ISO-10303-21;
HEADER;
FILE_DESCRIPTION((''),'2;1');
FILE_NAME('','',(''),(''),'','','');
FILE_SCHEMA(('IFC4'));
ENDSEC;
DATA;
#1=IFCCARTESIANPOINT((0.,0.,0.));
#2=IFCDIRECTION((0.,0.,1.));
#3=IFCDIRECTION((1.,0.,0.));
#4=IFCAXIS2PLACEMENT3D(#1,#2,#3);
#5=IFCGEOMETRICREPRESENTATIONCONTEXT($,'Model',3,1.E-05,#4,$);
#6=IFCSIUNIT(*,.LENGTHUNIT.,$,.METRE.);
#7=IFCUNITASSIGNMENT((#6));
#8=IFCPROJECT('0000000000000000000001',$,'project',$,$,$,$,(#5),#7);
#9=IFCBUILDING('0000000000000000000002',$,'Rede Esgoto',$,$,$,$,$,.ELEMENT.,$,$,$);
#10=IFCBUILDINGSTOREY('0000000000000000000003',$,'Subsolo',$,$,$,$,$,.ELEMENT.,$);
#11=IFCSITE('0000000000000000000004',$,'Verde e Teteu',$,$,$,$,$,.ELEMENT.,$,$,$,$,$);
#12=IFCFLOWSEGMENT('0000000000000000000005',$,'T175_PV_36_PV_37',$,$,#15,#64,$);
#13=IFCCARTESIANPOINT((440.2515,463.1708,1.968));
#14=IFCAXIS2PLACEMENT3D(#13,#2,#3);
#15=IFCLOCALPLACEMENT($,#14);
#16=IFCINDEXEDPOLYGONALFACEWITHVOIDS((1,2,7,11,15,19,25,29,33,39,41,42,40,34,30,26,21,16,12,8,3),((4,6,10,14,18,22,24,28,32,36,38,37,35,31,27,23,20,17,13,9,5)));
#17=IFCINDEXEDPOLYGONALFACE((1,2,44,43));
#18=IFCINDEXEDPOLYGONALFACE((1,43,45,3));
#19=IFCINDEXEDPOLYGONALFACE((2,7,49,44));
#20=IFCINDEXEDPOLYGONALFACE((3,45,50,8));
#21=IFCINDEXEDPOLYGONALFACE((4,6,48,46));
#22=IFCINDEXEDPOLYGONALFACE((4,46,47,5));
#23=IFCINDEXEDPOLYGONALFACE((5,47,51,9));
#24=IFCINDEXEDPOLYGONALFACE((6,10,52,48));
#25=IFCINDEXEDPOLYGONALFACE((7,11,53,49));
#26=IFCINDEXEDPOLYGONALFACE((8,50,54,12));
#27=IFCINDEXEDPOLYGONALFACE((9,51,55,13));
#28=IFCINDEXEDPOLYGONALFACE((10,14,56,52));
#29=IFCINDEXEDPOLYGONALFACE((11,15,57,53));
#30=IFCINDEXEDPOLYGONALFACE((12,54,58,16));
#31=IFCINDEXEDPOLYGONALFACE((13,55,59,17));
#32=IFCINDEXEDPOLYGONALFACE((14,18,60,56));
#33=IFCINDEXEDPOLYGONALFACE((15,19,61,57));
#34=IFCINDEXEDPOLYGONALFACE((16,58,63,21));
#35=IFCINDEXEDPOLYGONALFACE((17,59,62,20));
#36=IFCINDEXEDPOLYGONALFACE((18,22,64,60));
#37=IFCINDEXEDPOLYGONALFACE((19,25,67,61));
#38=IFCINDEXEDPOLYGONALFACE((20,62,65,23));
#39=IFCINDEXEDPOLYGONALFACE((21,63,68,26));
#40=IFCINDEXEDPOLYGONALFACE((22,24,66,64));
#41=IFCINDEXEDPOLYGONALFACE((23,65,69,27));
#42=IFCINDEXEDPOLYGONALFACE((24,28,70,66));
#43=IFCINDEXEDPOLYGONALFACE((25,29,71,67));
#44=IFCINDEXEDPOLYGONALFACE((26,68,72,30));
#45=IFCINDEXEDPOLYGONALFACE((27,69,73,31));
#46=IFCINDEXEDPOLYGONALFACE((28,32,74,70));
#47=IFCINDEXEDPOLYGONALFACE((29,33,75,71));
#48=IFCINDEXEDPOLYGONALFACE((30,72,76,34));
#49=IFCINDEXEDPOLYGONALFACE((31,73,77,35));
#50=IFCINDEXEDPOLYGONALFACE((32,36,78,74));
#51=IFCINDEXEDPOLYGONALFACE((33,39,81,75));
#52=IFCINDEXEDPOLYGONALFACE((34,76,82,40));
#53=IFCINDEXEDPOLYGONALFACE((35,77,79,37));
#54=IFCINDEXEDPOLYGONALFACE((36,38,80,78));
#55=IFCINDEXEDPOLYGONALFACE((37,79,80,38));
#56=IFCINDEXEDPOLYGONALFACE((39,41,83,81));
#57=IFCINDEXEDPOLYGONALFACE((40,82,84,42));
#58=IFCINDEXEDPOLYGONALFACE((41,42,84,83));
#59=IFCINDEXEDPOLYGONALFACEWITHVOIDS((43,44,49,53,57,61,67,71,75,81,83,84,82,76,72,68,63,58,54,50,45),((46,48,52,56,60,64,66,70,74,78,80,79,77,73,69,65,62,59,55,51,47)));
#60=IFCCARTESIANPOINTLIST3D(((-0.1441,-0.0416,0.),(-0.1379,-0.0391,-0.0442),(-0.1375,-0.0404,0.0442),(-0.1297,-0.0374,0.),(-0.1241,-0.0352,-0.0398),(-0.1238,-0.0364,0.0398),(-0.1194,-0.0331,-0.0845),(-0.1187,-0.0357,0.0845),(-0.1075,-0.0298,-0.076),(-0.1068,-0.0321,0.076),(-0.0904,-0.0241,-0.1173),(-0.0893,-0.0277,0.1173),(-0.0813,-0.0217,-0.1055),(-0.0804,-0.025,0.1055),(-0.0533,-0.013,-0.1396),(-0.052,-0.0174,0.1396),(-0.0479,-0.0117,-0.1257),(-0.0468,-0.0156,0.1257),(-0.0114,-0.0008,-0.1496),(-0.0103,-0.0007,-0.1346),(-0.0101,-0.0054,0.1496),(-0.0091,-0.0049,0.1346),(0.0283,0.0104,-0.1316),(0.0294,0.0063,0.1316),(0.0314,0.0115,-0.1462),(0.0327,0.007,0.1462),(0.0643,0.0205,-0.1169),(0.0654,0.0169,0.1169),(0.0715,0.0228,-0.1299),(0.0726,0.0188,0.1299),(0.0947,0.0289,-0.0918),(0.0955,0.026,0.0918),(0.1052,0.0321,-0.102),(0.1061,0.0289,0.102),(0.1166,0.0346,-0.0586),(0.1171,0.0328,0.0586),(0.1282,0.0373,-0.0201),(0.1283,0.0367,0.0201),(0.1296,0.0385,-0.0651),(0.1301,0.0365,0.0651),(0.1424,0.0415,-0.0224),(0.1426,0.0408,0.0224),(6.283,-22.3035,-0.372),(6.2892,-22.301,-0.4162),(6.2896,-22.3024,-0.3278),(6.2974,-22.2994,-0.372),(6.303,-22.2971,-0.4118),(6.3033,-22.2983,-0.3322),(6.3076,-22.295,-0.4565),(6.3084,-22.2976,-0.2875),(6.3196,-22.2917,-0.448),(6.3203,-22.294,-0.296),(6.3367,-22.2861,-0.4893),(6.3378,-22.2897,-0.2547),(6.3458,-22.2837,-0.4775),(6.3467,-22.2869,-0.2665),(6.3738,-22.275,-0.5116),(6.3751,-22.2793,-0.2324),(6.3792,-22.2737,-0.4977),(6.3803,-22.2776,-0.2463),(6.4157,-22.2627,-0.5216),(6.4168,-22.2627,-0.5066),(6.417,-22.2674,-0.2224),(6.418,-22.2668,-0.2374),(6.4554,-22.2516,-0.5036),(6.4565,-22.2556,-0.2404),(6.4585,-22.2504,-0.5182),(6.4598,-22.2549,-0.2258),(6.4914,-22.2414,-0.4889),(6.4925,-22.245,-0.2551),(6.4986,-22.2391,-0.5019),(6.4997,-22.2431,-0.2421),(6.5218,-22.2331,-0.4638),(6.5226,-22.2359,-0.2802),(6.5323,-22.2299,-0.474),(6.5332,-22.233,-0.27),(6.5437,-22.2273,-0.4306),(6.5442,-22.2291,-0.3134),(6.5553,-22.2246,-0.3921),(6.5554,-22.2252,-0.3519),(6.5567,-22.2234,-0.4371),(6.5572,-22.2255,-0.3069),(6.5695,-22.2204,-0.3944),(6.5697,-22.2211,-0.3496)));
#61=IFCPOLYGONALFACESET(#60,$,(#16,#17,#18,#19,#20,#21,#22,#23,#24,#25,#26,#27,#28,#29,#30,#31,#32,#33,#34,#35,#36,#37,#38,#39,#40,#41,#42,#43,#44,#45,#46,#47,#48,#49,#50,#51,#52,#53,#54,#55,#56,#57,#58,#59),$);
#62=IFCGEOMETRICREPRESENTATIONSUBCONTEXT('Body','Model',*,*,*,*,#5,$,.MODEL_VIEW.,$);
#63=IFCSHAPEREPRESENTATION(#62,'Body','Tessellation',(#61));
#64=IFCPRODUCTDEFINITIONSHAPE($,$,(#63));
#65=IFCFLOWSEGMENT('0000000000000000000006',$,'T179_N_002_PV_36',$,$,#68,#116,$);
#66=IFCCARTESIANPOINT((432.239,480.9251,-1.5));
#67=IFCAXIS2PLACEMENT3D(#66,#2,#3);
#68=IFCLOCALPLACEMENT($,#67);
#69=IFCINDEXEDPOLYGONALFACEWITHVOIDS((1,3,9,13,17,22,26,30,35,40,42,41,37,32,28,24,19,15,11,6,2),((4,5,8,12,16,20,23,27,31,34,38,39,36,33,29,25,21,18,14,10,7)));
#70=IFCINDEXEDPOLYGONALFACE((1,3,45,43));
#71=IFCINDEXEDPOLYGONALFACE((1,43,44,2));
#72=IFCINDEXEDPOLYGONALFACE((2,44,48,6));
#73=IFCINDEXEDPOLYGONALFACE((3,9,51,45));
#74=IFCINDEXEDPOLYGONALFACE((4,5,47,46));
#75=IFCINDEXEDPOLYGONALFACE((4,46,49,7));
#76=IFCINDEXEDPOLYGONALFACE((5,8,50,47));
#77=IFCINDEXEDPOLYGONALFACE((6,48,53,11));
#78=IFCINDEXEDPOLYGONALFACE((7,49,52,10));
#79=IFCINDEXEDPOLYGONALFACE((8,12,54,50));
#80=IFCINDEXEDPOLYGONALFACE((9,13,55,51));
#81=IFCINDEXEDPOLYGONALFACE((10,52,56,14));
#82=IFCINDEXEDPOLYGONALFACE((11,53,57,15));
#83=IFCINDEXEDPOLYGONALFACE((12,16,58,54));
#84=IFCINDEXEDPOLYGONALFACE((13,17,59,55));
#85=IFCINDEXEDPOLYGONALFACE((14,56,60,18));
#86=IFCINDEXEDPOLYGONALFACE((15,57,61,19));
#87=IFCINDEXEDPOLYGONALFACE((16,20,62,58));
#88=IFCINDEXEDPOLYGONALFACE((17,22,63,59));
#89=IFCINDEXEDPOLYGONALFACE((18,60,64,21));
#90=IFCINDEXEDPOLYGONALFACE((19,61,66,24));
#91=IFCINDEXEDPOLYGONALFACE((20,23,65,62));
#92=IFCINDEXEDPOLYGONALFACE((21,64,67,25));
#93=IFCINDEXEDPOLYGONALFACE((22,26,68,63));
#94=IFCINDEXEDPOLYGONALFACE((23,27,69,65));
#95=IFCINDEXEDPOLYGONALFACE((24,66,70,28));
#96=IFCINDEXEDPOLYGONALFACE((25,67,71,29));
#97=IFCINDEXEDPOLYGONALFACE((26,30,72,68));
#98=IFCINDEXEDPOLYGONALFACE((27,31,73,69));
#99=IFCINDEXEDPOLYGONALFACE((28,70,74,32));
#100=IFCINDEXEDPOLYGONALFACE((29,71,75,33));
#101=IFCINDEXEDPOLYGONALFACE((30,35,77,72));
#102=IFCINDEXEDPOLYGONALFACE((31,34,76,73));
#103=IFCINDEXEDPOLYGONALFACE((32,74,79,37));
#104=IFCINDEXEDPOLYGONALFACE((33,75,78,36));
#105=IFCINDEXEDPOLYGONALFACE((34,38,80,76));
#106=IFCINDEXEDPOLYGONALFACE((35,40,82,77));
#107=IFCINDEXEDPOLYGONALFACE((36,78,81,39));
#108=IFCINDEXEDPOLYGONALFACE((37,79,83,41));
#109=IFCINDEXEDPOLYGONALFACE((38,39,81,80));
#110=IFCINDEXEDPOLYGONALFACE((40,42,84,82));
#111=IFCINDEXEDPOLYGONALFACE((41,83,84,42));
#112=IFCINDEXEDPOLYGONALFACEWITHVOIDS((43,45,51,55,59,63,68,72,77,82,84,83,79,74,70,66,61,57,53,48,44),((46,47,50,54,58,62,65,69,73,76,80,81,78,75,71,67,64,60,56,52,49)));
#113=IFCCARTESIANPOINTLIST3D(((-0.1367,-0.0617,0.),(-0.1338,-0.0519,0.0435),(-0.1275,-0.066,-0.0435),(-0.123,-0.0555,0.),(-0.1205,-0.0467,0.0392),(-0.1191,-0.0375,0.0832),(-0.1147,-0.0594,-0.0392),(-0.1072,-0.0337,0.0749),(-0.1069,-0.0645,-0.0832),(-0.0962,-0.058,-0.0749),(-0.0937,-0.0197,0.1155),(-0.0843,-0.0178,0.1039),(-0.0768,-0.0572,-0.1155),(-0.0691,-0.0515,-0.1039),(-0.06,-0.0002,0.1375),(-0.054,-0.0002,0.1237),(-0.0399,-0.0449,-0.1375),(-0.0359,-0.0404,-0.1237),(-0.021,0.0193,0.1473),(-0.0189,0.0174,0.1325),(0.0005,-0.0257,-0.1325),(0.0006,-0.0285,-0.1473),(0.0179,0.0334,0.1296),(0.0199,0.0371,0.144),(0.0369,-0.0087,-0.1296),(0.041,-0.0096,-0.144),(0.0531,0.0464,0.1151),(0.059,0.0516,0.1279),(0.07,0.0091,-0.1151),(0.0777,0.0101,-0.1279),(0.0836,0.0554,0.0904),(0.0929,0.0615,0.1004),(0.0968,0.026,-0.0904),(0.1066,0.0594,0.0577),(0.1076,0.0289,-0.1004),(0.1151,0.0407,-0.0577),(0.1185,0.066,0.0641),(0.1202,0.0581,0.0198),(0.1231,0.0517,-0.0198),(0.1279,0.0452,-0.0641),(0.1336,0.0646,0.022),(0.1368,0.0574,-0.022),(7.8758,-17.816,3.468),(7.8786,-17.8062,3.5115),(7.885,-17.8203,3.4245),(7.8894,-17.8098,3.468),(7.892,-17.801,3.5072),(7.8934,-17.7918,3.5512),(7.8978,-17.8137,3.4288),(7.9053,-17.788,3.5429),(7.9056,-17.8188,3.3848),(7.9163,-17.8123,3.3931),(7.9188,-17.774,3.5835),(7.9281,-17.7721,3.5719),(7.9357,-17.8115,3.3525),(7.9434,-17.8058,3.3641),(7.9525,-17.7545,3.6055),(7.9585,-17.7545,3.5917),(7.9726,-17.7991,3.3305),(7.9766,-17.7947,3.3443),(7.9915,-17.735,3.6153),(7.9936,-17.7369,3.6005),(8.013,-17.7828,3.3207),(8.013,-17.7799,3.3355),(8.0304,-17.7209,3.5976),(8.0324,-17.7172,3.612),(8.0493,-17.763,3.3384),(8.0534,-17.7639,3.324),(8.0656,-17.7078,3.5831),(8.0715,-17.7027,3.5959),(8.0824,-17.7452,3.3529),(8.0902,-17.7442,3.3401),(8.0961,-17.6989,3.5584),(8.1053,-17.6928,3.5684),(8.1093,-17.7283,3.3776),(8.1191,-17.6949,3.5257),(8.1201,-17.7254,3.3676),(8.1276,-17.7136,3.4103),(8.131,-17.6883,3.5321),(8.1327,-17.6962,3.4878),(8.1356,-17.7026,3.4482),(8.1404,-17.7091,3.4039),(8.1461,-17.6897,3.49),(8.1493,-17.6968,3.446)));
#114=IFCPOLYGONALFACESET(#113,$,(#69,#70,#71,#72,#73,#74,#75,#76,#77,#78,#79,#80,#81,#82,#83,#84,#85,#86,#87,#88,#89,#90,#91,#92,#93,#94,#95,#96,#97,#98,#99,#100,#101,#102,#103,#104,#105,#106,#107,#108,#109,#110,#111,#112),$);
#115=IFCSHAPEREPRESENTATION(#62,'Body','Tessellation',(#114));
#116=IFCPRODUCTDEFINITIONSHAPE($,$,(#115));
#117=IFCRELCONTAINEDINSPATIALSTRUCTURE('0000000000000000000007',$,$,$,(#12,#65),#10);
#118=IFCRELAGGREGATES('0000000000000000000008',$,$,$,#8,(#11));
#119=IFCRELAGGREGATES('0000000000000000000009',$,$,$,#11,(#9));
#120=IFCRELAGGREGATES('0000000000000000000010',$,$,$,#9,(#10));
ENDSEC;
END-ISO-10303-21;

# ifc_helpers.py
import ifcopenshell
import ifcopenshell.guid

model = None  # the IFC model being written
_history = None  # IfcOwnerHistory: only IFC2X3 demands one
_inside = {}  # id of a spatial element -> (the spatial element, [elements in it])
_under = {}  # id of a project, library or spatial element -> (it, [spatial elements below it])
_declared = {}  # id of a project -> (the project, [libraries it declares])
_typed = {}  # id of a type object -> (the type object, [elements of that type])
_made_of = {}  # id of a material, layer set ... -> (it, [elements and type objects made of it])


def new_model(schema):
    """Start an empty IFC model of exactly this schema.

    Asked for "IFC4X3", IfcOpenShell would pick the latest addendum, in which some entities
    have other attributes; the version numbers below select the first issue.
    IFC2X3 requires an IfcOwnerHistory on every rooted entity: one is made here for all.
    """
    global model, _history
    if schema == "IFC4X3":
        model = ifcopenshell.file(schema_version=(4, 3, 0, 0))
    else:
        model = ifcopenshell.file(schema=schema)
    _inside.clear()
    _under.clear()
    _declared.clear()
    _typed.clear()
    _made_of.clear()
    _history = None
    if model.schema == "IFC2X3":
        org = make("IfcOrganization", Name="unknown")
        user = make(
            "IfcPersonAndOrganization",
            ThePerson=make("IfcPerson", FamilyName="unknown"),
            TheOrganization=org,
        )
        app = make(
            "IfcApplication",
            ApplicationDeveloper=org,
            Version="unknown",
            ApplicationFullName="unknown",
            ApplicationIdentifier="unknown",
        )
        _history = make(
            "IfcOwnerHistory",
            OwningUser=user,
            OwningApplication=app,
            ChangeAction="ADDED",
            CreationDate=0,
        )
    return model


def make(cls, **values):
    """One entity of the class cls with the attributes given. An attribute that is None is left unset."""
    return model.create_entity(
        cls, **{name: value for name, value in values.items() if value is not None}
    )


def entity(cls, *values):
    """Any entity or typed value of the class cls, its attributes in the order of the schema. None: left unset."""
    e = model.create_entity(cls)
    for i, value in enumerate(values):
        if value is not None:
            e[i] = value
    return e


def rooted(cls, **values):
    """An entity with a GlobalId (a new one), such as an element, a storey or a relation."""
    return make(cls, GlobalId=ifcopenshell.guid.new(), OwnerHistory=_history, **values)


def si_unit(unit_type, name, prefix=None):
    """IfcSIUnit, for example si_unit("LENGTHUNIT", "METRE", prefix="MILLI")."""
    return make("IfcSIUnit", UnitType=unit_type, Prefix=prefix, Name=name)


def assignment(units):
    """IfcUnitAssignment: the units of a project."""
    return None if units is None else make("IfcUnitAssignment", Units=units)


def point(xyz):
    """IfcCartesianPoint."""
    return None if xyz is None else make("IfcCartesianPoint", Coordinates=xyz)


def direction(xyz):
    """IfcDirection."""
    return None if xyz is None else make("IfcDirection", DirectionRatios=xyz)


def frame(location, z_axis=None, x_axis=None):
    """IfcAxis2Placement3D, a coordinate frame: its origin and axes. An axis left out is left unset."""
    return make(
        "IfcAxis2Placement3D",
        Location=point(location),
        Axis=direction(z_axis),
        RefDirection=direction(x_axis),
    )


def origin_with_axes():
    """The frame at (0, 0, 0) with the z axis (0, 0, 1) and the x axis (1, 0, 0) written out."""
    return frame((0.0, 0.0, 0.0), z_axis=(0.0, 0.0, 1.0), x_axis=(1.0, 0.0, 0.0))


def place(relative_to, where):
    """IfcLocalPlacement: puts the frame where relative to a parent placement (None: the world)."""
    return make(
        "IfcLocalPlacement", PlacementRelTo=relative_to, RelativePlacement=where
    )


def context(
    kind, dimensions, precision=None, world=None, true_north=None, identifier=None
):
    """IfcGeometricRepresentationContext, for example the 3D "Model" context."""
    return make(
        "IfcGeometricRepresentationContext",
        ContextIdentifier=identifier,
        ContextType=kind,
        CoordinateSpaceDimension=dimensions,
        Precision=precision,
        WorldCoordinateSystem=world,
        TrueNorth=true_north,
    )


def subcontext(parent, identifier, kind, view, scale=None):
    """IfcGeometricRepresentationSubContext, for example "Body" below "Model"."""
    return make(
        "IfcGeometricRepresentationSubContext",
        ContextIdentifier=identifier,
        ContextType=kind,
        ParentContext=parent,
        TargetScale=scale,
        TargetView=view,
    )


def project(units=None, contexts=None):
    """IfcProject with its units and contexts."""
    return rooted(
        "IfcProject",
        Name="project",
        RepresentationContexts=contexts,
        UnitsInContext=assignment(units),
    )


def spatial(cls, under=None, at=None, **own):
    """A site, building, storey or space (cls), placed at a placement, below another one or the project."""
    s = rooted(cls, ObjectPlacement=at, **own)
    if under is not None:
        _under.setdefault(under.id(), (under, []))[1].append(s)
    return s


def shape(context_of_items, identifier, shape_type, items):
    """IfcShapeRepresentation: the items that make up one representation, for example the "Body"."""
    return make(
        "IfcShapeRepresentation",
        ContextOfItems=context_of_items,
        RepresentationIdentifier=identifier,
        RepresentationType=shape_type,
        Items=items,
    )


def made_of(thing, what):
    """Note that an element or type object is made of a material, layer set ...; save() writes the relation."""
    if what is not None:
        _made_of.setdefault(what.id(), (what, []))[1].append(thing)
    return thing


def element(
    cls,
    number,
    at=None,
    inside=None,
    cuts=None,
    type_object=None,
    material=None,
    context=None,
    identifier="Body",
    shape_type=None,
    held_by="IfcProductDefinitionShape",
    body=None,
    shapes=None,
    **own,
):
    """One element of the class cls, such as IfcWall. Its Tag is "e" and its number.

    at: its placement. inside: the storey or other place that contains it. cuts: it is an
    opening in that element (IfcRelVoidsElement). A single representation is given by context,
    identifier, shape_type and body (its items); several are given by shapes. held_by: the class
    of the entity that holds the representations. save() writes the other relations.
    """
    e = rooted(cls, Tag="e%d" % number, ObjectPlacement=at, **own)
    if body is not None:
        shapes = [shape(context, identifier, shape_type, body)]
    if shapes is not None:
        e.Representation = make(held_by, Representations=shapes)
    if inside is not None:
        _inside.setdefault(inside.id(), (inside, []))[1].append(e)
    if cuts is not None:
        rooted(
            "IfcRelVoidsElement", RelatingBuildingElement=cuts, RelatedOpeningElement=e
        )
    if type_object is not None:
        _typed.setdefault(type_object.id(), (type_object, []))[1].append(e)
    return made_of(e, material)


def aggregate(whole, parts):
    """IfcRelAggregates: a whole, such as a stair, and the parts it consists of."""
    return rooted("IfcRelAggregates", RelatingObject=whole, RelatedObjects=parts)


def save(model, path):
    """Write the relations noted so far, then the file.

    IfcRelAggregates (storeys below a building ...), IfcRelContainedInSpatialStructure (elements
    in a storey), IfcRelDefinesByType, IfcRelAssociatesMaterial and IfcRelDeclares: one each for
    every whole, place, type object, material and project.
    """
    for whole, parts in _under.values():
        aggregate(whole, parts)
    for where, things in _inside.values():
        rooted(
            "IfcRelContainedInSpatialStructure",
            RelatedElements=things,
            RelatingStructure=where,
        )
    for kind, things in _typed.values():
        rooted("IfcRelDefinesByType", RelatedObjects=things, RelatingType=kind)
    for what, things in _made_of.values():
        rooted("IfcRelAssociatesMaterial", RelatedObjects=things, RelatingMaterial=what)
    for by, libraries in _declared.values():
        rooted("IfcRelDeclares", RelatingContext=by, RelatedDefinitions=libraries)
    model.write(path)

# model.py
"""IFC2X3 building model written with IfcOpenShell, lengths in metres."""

from ifc_helpers import new_model, entity, si_unit, frame, origin_with_axes, place, context, subcontext, project, spatial, element, save


model = new_model("IFC2X3")

# Units and contexts
model_context = context("Model", 3, precision=1e-05, world=origin_with_axes())
body_context = subcontext(model_context, "Body", "Model", "MODEL_VIEW")
ifc_project = project(units=[si_unit("LENGTHUNIT", "METRE")], contexts=[model_context])

# Site, building, storey
site = spatial("IfcSite", under=ifc_project, Name="Verde e Teteu", CompositionType="ELEMENT")
building = spatial("IfcBuilding", under=site, Name="Rede Esgoto", CompositionType="ELEMENT")
storey = spatial("IfcBuildingStorey", under=building, Name="Subsolo", CompositionType="ELEMENT")

# Flow segments
flow_segment_1_placement = place(None, frame((440.2515, 463.1708, 1.968), z_axis=(0.0, 0.0, 1.0), x_axis=(1.0, 0.0, 0.0)))
element("IfcFlowSegment", 1, at=flow_segment_1_placement, inside=storey, Name="T175_PV_36_PV_37", context=body_context, shape_type="SweptSolid", body=[
    entity("IfcSweptDiskSolid", entity("IfcPolyline", [entity("IfcCartesianPoint", [0.0, 0.0, 0.0]), entity("IfcCartesianPoint", [6.4271, -22.2619, -0.372])]), 0.15, 0.135),
])
flow_segment_2_placement = place(None, frame((432.239, 480.9251, -1.5), z_axis=(0.0, 0.0, 1.0), x_axis=(1.0, 0.0, 0.0)))
element("IfcFlowSegment", 2, at=flow_segment_2_placement, inside=storey, Name="T179_N_002_PV_36", context=body_context, shape_type="SweptSolid", body=[
    entity("IfcSweptDiskSolid", entity("IfcPolyline", [entity("IfcCartesianPoint", [0.0, 0.0, 0.0]), entity("IfcCartesianPoint", [8.0125, -17.7543, 3.468])]), 0.15, 0.135),
])

save(model, "model.ifc")
